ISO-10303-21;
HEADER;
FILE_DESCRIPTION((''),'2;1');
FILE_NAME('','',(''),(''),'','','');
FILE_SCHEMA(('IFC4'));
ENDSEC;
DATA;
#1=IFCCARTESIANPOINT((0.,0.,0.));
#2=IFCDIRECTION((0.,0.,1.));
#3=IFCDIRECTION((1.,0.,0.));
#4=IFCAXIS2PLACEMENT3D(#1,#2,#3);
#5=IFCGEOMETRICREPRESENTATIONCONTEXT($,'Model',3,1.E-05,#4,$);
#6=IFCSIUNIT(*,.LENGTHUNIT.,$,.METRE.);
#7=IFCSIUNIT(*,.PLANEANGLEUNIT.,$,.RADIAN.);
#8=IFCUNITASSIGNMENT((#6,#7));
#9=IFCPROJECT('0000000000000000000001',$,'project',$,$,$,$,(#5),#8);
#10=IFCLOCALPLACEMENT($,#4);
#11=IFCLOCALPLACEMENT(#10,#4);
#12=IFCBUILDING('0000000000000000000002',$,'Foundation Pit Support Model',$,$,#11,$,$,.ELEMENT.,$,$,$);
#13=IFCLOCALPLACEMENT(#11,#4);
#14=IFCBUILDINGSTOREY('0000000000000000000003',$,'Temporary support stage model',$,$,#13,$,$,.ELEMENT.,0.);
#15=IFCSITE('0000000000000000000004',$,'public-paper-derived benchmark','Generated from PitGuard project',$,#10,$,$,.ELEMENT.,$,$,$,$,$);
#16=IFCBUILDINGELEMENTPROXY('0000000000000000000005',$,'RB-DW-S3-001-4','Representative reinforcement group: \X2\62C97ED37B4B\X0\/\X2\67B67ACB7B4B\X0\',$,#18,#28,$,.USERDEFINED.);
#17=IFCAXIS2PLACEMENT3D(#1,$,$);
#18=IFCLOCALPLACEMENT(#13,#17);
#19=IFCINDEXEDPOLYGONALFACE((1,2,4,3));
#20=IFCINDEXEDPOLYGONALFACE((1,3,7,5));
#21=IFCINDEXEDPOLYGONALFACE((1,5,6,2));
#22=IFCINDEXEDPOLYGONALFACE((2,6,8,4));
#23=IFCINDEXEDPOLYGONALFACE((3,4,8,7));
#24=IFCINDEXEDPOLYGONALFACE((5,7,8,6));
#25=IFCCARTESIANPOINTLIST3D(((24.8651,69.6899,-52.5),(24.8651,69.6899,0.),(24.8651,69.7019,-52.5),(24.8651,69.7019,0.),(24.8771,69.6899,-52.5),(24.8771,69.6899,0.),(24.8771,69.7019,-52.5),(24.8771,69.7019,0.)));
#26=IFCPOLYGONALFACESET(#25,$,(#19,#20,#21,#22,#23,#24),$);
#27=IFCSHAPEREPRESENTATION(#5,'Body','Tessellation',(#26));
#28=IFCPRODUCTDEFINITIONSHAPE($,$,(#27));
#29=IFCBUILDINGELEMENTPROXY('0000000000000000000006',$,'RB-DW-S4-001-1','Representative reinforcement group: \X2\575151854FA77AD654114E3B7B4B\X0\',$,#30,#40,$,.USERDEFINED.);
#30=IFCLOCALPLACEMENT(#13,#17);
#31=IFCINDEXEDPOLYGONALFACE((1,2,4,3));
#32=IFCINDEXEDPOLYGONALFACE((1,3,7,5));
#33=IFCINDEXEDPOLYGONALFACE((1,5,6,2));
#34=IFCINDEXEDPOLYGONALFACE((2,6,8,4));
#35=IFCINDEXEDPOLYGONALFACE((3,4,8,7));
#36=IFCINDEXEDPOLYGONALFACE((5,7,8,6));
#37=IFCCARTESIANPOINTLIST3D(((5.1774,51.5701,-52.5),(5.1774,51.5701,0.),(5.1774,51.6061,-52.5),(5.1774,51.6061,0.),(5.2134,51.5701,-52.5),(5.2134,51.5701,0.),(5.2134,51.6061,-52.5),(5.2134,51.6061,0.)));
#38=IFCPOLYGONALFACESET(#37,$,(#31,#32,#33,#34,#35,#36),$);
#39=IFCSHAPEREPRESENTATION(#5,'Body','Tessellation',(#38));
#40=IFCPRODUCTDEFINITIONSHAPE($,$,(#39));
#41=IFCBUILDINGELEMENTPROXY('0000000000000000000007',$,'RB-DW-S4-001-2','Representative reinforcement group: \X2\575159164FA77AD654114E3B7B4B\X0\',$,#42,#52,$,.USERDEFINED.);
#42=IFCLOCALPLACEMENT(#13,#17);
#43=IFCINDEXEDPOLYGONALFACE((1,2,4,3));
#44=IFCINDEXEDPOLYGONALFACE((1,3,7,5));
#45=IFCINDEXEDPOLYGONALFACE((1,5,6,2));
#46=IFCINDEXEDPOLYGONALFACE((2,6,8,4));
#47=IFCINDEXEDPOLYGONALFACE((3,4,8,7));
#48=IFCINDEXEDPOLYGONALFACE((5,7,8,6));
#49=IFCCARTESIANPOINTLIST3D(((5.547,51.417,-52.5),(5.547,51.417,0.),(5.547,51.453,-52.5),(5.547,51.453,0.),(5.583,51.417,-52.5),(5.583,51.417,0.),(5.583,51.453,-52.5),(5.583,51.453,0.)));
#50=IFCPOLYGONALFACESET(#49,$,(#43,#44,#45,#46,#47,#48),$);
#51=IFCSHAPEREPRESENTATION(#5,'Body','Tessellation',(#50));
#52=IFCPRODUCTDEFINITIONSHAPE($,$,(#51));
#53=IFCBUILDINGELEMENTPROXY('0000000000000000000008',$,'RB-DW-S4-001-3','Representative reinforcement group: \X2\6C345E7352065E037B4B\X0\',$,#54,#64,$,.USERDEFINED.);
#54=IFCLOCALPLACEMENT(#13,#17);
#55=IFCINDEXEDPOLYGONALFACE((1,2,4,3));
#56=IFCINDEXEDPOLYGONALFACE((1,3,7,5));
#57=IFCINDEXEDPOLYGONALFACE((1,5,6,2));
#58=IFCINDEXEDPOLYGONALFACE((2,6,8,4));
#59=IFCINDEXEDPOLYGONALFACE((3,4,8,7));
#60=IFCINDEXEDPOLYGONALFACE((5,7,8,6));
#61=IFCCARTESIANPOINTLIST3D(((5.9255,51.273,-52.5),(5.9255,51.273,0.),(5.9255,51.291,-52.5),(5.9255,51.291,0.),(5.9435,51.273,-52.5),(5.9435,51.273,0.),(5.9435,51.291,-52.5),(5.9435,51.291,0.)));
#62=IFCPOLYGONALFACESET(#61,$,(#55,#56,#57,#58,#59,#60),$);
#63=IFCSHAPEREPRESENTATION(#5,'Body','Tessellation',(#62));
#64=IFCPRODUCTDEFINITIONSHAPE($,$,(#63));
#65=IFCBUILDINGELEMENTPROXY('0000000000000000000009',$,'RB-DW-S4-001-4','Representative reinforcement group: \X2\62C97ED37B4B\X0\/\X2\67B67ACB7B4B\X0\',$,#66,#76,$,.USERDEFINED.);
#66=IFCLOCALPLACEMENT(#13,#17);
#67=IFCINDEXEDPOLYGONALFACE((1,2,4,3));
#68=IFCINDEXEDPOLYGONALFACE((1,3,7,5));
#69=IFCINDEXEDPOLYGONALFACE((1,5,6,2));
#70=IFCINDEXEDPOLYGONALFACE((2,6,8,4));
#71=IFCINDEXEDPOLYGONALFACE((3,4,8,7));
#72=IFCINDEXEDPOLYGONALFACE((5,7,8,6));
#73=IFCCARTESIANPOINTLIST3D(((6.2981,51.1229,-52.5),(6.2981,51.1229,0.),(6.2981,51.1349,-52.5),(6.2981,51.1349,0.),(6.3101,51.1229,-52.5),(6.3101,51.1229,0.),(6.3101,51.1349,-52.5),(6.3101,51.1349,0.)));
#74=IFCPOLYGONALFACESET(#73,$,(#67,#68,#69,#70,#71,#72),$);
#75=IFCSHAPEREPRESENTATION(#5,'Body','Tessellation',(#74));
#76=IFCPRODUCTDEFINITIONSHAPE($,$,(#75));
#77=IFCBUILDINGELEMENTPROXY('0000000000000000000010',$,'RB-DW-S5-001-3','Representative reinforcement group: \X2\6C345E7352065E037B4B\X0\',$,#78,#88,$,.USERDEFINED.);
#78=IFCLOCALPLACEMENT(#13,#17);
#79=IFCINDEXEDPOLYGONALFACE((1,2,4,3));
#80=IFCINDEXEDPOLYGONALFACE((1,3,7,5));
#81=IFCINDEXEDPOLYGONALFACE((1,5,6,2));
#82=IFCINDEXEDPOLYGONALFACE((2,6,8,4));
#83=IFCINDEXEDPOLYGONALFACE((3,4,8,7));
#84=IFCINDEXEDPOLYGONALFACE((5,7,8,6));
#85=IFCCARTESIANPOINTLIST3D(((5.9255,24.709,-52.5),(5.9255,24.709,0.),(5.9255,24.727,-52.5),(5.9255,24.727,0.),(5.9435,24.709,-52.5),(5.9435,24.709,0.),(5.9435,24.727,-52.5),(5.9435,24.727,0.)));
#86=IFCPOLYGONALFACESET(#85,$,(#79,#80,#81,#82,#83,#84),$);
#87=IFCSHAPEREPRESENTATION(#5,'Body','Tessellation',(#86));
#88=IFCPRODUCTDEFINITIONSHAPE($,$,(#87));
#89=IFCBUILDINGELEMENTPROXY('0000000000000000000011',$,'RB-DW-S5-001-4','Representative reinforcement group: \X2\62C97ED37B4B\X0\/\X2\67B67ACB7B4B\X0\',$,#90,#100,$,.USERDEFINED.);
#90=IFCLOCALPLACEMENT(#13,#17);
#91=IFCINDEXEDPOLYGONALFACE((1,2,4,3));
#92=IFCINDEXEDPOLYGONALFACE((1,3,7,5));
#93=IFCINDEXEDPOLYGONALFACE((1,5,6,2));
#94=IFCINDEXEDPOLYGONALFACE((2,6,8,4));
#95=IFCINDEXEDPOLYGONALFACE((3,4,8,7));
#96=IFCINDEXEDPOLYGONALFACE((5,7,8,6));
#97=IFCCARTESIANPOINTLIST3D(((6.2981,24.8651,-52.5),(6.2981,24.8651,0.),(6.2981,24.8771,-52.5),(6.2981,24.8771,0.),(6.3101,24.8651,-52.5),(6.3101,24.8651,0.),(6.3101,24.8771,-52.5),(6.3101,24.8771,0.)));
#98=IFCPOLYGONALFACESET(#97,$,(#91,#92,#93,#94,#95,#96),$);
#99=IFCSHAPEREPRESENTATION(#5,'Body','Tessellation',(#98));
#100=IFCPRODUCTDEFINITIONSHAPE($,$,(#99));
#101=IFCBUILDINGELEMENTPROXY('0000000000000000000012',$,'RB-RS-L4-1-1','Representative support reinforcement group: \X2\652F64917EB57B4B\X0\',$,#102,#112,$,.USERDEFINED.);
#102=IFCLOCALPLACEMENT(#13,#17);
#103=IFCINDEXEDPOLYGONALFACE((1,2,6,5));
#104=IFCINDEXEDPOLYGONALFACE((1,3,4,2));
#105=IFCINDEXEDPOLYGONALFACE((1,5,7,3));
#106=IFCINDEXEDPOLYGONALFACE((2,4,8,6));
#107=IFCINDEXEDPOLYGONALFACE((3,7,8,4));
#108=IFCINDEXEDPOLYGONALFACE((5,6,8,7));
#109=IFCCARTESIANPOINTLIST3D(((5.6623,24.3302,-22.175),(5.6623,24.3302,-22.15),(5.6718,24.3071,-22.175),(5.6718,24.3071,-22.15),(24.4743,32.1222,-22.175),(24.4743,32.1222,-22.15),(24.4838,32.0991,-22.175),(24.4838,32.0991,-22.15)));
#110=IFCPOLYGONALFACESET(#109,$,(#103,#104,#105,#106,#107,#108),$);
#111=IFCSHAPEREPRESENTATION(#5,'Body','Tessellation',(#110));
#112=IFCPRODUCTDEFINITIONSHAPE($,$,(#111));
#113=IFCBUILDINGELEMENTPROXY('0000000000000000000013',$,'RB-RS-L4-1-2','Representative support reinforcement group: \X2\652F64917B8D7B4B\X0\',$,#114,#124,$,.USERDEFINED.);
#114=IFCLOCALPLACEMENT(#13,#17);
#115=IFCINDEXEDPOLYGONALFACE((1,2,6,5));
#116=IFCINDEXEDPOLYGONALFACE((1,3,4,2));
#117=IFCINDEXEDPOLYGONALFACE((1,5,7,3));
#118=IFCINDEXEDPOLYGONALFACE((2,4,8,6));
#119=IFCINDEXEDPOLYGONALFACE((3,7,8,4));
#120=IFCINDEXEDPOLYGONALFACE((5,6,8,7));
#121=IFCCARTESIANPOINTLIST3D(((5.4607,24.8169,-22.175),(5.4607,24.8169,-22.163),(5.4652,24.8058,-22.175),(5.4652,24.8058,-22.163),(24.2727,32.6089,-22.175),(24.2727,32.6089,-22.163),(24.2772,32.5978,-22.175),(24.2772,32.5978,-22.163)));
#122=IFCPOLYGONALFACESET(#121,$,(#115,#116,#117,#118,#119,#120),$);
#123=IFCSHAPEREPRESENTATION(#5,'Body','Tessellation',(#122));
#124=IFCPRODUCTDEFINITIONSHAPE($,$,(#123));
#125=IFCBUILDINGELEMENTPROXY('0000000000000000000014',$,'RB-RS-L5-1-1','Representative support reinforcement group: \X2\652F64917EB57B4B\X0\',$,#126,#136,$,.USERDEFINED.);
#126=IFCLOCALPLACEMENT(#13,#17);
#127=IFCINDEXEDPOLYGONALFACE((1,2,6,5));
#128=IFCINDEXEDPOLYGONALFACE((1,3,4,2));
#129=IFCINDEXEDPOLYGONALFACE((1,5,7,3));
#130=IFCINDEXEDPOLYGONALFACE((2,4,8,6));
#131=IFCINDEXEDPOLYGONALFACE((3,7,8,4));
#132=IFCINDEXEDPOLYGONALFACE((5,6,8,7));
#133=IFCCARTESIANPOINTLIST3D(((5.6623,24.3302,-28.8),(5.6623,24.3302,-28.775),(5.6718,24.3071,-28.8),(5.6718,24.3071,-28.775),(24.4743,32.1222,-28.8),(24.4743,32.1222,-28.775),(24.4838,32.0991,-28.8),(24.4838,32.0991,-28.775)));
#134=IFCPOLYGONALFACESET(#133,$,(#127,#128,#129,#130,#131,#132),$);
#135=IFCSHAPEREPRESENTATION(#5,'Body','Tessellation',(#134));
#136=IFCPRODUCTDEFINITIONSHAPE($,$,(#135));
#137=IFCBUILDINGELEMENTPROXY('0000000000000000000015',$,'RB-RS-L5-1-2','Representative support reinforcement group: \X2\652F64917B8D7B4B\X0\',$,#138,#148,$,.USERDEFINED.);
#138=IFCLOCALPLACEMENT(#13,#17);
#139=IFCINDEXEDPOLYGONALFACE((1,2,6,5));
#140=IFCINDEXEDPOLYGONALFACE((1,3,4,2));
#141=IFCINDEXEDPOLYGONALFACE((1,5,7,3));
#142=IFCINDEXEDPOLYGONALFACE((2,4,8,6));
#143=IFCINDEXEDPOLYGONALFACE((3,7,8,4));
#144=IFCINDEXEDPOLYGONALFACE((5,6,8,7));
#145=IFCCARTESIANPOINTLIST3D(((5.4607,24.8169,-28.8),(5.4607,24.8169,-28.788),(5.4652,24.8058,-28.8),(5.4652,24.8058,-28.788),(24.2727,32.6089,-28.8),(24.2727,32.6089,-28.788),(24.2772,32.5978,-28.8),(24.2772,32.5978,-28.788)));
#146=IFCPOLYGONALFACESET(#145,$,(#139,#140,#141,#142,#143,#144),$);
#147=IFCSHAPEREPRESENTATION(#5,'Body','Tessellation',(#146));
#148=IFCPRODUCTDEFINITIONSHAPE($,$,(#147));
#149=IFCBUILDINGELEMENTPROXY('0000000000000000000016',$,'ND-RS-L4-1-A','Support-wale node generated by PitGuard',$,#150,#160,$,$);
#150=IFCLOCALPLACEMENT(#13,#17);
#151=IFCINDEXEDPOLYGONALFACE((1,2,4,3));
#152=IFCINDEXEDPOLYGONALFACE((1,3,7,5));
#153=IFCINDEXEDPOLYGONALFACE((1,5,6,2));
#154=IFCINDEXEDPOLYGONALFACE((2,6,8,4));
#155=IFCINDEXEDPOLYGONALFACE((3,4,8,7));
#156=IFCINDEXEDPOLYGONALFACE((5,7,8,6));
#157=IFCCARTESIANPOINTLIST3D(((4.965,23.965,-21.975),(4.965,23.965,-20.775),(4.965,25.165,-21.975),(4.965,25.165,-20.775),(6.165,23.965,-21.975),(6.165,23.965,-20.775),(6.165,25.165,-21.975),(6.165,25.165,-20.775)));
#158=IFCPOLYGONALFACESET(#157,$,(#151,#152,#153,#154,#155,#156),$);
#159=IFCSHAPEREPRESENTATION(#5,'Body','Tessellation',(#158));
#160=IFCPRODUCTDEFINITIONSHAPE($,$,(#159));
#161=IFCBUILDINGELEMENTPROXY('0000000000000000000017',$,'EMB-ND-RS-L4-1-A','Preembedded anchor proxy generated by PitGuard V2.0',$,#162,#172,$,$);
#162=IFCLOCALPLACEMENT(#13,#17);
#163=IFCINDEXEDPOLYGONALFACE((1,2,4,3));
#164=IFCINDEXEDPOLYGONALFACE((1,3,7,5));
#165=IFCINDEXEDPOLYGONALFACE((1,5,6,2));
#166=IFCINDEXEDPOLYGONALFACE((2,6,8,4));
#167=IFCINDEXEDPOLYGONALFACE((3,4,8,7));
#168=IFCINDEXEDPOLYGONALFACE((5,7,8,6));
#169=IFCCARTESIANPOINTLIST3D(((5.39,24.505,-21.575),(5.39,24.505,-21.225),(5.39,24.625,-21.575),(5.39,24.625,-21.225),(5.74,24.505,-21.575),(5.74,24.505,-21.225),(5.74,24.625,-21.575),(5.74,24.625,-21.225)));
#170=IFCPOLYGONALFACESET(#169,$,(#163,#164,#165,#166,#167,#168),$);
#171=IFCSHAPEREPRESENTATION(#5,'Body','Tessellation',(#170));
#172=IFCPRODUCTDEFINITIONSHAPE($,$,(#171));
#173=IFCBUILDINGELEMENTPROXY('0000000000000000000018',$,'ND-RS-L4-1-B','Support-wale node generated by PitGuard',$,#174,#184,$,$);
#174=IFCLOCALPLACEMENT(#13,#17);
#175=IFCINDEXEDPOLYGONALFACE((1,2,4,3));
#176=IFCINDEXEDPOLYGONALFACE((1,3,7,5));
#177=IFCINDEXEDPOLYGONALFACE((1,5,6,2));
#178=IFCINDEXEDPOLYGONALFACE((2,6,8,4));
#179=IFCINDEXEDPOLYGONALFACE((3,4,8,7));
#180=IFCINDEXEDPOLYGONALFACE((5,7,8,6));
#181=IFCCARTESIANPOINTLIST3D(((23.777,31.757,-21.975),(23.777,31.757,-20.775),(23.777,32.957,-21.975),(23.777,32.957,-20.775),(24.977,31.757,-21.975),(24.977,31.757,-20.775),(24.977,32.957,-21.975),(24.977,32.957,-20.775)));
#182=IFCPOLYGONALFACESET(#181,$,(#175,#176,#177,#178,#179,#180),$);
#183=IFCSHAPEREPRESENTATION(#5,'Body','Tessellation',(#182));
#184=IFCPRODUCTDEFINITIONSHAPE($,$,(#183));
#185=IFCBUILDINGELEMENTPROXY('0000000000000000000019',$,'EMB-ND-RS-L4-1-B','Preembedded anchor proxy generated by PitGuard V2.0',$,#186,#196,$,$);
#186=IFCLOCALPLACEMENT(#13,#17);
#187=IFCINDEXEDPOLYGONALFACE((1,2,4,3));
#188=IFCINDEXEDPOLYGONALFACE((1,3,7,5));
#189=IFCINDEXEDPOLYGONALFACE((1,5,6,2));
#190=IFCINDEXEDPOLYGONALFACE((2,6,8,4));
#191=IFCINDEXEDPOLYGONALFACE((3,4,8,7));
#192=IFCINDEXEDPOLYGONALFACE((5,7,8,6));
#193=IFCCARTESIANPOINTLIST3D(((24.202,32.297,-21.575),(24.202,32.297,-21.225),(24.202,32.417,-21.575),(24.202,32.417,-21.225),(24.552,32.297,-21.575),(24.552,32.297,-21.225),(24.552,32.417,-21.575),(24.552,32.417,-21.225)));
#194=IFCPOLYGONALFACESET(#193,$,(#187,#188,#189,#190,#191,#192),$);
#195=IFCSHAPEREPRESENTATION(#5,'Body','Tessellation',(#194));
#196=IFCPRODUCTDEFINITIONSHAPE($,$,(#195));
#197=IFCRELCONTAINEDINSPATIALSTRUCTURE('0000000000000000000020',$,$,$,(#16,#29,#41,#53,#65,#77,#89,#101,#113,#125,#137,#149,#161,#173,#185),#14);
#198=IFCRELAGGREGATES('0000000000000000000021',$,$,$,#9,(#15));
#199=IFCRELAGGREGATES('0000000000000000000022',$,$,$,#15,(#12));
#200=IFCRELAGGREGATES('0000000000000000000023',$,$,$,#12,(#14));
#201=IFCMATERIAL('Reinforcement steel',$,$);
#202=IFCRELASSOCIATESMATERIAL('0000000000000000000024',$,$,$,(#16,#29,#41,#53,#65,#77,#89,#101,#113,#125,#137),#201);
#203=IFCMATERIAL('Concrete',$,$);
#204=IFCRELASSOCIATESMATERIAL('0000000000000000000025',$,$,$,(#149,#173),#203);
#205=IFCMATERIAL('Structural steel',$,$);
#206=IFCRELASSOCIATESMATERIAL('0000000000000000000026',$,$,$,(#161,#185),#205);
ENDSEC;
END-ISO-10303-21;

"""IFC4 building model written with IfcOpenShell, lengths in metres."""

from ifc_helpers import new_model, si_unit, frame, origin_with_axes, origin_2d, place, context, project, spatial, rectangle, extrude, material, element, save


model = new_model("IFC4")

# Units and contexts
model_context = context("Model", 3, precision=1e-05, world=origin_with_axes())
ifc_project = project(units=[si_unit("LENGTHUNIT", "METRE"), si_unit("PLANEANGLEUNIT", "RADIAN")], contexts=[model_context])

# Site, building, storey
site_placement = place(None, origin_with_axes())
site = spatial("IfcSite", under=ifc_project, at=site_placement, Name="public-paper-derived benchmark", Description="Generated from PitGuard project", CompositionType="ELEMENT")
building_placement = place(site_placement, origin_with_axes())
building = spatial("IfcBuilding", under=site, at=building_placement, Name="Foundation Pit Support Model", CompositionType="ELEMENT")
storey_placement = place(building_placement, origin_with_axes())
storey = spatial("IfcBuildingStorey", under=building, at=storey_placement, Name="Temporary support stage model", CompositionType="ELEMENT", Elevation=0.0)

# Shared definitions
ifc_material_1 = material(Name="Structural steel")

# Shared definitions
ifc_material_2 = material(Name="Concrete")

# Building element proxies
ifc_material_3 = material(Name="Reinforcement steel")
proxy_1_placement = place(storey_placement, frame((24.8711, 69.6959, -52.5), z_axis=(0.0, 0.0, 1.0), x_axis=(1.0, 0.0, 0.0)))
element("IfcBuildingElementProxy", 1, at=proxy_1_placement, inside=storey, material=ifc_material_3, Name="RB-DW-S3-001-4", Description="Representative reinforcement group: 拉结筋/架立筋", PredefinedType="USERDEFINED", context=model_context, shape_type="SweptSolid", body=[
    extrude(rectangle(XDim=0.012, YDim=0.012, at=origin_2d()), origin_with_axes(), (0.0, 0.0, 1.0), 52.5),
])
for number, where, z_axis, x_axis, name, description in (
    (2, (5.1954, 51.5881, -52.5), (0.0, 0.0, 1.0), (1.0, 0.0, 0.0), "RB-DW-S4-001-1", "Representative reinforcement group: 坑内侧竖向主筋"),
    (3, (5.565, 51.435, -52.5), (0.0, 0.0, 1.0), (1.0, 0.0, 0.0), "RB-DW-S4-001-2", "Representative reinforcement group: 坑外侧竖向主筋"),
):
    element("IfcBuildingElementProxy", number, at=place(storey_placement, frame(where, z_axis=z_axis, x_axis=x_axis)), inside=storey, material=ifc_material_3, Name=name, Description=description, PredefinedType="USERDEFINED", context=model_context, shape_type="SweptSolid", body=[
        extrude(rectangle(XDim=0.036, YDim=0.036, at=origin_2d()), origin_with_axes(), (0.0, 0.0, 1.0), 52.5),
    ])
proxy_2_placement = place(storey_placement, frame((5.9345, 51.282, -52.5), z_axis=(0.0, 0.0, 1.0), x_axis=(1.0, 0.0, 0.0)))
element("IfcBuildingElementProxy", 4, at=proxy_2_placement, inside=storey, material=ifc_material_3, Name="RB-DW-S4-001-3", Description="Representative reinforcement group: 水平分布筋", PredefinedType="USERDEFINED", context=model_context, shape_type="SweptSolid", body=[
    extrude(rectangle(XDim=0.018, YDim=0.018, at=origin_2d()), origin_with_axes(), (0.0, 0.0, 1.0), 52.5),
])
proxy_3_placement = place(storey_placement, frame((6.3041, 51.1289, -52.5), z_axis=(0.0, 0.0, 1.0), x_axis=(1.0, 0.0, 0.0)))
element("IfcBuildingElementProxy", 5, at=proxy_3_placement, inside=storey, material=ifc_material_3, Name="RB-DW-S4-001-4", Description="Representative reinforcement group: 拉结筋/架立筋", PredefinedType="USERDEFINED", context=model_context, shape_type="SweptSolid", body=[
    extrude(rectangle(XDim=0.012, YDim=0.012, at=origin_2d()), origin_with_axes(), (0.0, 0.0, 1.0), 52.5),
])
proxy_4_placement = place(storey_placement, frame((5.9345, 24.718, -52.5), z_axis=(0.0, 0.0, 1.0), x_axis=(1.0, 0.0, 0.0)))
element("IfcBuildingElementProxy", 6, at=proxy_4_placement, inside=storey, material=ifc_material_3, Name="RB-DW-S5-001-3", Description="Representative reinforcement group: 水平分布筋", PredefinedType="USERDEFINED", context=model_context, shape_type="SweptSolid", body=[
    extrude(rectangle(XDim=0.018, YDim=0.018, at=origin_2d()), origin_with_axes(), (0.0, 0.0, 1.0), 52.5),
])
proxy_5_placement = place(storey_placement, frame((6.3041, 24.8711, -52.5), z_axis=(0.0, 0.0, 1.0), x_axis=(1.0, 0.0, 0.0)))
element("IfcBuildingElementProxy", 7, at=proxy_5_placement, inside=storey, material=ifc_material_3, Name="RB-DW-S5-001-4", Description="Representative reinforcement group: 拉结筋/架立筋", PredefinedType="USERDEFINED", context=model_context, shape_type="SweptSolid", body=[
    extrude(rectangle(XDim=0.012, YDim=0.012, at=origin_2d()), origin_with_axes(), (0.0, 0.0, 1.0), 52.5),
])
proxy_6_placement = place(storey_placement, frame((15.073, 28.2146, -22.175), z_axis=(0.0, 0.0, 1.0), x_axis=(0.923883, 0.382676, 0.0)))
element("IfcBuildingElementProxy", 8, at=proxy_6_placement, inside=storey, material=ifc_material_3, Name="RB-RS-L4-1-1", Description="Representative support reinforcement group: 支撑纵筋", PredefinedType="USERDEFINED", context=model_context, shape_type="SweptSolid", body=[
    extrude(rectangle(XDim=20.3619, YDim=0.025, at=origin_2d()), origin_with_axes(), (0.0, 0.0, 1.0), 0.025),
])
proxy_7_placement = place(storey_placement, frame((14.869, 28.7074, -22.175), z_axis=(0.0, 0.0, 1.0), x_axis=(0.923883, 0.382676, 0.0)))
element("IfcBuildingElementProxy", 9, at=proxy_7_placement, inside=storey, material=ifc_material_3, Name="RB-RS-L4-1-2", Description="Representative support reinforcement group: 支撑箍筋", PredefinedType="USERDEFINED", context=model_context, shape_type="SweptSolid", body=[
    extrude(rectangle(XDim=20.3619, YDim=0.012, at=origin_2d()), origin_with_axes(), (0.0, 0.0, 1.0), 0.012),
])
proxy_8_placement = place(storey_placement, frame((15.073, 28.2146, -28.8), z_axis=(0.0, 0.0, 1.0), x_axis=(0.923883, 0.382676, 0.0)))
element("IfcBuildingElementProxy", 10, at=proxy_8_placement, inside=storey, material=ifc_material_3, Name="RB-RS-L5-1-1", Description="Representative support reinforcement group: 支撑纵筋", PredefinedType="USERDEFINED", context=model_context, shape_type="SweptSolid", body=[
    extrude(rectangle(XDim=20.3619, YDim=0.025, at=origin_2d()), origin_with_axes(), (0.0, 0.0, 1.0), 0.025),
])
proxy_9_placement = place(storey_placement, frame((14.869, 28.7074, -28.8), z_axis=(0.0, 0.0, 1.0), x_axis=(0.923883, 0.382676, 0.0)))
element("IfcBuildingElementProxy", 11, at=proxy_9_placement, inside=storey, material=ifc_material_3, Name="RB-RS-L5-1-2", Description="Representative support reinforcement group: 支撑箍筋", PredefinedType="USERDEFINED", context=model_context, shape_type="SweptSolid", body=[
    extrude(rectangle(XDim=20.3619, YDim=0.012, at=origin_2d()), origin_with_axes(), (0.0, 0.0, 1.0), 0.012),
])
proxy_10_placement = place(storey_placement, frame((5.565, 24.565, -21.975), z_axis=(0.0, 0.0, 1.0), x_axis=(1.0, 0.0, 0.0)))
element("IfcBuildingElementProxy", 12, at=proxy_10_placement, inside=storey, material=ifc_material_2, Name="ND-RS-L4-1-A", Description="Support-wale node generated by PitGuard", context=model_context, shape_type="SweptSolid", body=[
    extrude(rectangle(XDim=1.2, YDim=1.2, at=origin_2d()), origin_with_axes(), (0.0, 0.0, 1.0), 1.2),
])
proxy_11_placement = place(storey_placement, frame((5.565, 24.565, -21.575), z_axis=(0.0, 0.0, 1.0), x_axis=(1.0, 0.0, 0.0)))
element("IfcBuildingElementProxy", 13, at=proxy_11_placement, inside=storey, material=ifc_material_1, Name="EMB-ND-RS-L4-1-A", Description="Preembedded anchor proxy generated by PitGuard V2.0", context=model_context, shape_type="SweptSolid", body=[
    extrude(rectangle(XDim=0.35, YDim=0.12, at=origin_2d()), origin_with_axes(), (0.0, 0.0, 1.0), 0.35),
])
proxy_12_placement = place(storey_placement, frame((24.377, 32.357, -21.975), z_axis=(0.0, 0.0, 1.0), x_axis=(1.0, 0.0, 0.0)))
element("IfcBuildingElementProxy", 14, at=proxy_12_placement, inside=storey, material=ifc_material_2, Name="ND-RS-L4-1-B", Description="Support-wale node generated by PitGuard", context=model_context, shape_type="SweptSolid", body=[
    extrude(rectangle(XDim=1.2, YDim=1.2, at=origin_2d()), origin_with_axes(), (0.0, 0.0, 1.0), 1.2),
])
proxy_13_placement = place(storey_placement, frame((24.377, 32.357, -21.575), z_axis=(0.0, 0.0, 1.0), x_axis=(1.0, 0.0, 0.0)))
element("IfcBuildingElementProxy", 15, at=proxy_13_placement, inside=storey, material=ifc_material_1, Name="EMB-ND-RS-L4-1-B", Description="Preembedded anchor proxy generated by PitGuard V2.0", context=model_context, shape_type="SweptSolid", body=[
    extrude(rectangle(XDim=0.35, YDim=0.12, at=origin_2d()), origin_with_axes(), (0.0, 0.0, 1.0), 0.35),
])

save(model, "model.ifc")
